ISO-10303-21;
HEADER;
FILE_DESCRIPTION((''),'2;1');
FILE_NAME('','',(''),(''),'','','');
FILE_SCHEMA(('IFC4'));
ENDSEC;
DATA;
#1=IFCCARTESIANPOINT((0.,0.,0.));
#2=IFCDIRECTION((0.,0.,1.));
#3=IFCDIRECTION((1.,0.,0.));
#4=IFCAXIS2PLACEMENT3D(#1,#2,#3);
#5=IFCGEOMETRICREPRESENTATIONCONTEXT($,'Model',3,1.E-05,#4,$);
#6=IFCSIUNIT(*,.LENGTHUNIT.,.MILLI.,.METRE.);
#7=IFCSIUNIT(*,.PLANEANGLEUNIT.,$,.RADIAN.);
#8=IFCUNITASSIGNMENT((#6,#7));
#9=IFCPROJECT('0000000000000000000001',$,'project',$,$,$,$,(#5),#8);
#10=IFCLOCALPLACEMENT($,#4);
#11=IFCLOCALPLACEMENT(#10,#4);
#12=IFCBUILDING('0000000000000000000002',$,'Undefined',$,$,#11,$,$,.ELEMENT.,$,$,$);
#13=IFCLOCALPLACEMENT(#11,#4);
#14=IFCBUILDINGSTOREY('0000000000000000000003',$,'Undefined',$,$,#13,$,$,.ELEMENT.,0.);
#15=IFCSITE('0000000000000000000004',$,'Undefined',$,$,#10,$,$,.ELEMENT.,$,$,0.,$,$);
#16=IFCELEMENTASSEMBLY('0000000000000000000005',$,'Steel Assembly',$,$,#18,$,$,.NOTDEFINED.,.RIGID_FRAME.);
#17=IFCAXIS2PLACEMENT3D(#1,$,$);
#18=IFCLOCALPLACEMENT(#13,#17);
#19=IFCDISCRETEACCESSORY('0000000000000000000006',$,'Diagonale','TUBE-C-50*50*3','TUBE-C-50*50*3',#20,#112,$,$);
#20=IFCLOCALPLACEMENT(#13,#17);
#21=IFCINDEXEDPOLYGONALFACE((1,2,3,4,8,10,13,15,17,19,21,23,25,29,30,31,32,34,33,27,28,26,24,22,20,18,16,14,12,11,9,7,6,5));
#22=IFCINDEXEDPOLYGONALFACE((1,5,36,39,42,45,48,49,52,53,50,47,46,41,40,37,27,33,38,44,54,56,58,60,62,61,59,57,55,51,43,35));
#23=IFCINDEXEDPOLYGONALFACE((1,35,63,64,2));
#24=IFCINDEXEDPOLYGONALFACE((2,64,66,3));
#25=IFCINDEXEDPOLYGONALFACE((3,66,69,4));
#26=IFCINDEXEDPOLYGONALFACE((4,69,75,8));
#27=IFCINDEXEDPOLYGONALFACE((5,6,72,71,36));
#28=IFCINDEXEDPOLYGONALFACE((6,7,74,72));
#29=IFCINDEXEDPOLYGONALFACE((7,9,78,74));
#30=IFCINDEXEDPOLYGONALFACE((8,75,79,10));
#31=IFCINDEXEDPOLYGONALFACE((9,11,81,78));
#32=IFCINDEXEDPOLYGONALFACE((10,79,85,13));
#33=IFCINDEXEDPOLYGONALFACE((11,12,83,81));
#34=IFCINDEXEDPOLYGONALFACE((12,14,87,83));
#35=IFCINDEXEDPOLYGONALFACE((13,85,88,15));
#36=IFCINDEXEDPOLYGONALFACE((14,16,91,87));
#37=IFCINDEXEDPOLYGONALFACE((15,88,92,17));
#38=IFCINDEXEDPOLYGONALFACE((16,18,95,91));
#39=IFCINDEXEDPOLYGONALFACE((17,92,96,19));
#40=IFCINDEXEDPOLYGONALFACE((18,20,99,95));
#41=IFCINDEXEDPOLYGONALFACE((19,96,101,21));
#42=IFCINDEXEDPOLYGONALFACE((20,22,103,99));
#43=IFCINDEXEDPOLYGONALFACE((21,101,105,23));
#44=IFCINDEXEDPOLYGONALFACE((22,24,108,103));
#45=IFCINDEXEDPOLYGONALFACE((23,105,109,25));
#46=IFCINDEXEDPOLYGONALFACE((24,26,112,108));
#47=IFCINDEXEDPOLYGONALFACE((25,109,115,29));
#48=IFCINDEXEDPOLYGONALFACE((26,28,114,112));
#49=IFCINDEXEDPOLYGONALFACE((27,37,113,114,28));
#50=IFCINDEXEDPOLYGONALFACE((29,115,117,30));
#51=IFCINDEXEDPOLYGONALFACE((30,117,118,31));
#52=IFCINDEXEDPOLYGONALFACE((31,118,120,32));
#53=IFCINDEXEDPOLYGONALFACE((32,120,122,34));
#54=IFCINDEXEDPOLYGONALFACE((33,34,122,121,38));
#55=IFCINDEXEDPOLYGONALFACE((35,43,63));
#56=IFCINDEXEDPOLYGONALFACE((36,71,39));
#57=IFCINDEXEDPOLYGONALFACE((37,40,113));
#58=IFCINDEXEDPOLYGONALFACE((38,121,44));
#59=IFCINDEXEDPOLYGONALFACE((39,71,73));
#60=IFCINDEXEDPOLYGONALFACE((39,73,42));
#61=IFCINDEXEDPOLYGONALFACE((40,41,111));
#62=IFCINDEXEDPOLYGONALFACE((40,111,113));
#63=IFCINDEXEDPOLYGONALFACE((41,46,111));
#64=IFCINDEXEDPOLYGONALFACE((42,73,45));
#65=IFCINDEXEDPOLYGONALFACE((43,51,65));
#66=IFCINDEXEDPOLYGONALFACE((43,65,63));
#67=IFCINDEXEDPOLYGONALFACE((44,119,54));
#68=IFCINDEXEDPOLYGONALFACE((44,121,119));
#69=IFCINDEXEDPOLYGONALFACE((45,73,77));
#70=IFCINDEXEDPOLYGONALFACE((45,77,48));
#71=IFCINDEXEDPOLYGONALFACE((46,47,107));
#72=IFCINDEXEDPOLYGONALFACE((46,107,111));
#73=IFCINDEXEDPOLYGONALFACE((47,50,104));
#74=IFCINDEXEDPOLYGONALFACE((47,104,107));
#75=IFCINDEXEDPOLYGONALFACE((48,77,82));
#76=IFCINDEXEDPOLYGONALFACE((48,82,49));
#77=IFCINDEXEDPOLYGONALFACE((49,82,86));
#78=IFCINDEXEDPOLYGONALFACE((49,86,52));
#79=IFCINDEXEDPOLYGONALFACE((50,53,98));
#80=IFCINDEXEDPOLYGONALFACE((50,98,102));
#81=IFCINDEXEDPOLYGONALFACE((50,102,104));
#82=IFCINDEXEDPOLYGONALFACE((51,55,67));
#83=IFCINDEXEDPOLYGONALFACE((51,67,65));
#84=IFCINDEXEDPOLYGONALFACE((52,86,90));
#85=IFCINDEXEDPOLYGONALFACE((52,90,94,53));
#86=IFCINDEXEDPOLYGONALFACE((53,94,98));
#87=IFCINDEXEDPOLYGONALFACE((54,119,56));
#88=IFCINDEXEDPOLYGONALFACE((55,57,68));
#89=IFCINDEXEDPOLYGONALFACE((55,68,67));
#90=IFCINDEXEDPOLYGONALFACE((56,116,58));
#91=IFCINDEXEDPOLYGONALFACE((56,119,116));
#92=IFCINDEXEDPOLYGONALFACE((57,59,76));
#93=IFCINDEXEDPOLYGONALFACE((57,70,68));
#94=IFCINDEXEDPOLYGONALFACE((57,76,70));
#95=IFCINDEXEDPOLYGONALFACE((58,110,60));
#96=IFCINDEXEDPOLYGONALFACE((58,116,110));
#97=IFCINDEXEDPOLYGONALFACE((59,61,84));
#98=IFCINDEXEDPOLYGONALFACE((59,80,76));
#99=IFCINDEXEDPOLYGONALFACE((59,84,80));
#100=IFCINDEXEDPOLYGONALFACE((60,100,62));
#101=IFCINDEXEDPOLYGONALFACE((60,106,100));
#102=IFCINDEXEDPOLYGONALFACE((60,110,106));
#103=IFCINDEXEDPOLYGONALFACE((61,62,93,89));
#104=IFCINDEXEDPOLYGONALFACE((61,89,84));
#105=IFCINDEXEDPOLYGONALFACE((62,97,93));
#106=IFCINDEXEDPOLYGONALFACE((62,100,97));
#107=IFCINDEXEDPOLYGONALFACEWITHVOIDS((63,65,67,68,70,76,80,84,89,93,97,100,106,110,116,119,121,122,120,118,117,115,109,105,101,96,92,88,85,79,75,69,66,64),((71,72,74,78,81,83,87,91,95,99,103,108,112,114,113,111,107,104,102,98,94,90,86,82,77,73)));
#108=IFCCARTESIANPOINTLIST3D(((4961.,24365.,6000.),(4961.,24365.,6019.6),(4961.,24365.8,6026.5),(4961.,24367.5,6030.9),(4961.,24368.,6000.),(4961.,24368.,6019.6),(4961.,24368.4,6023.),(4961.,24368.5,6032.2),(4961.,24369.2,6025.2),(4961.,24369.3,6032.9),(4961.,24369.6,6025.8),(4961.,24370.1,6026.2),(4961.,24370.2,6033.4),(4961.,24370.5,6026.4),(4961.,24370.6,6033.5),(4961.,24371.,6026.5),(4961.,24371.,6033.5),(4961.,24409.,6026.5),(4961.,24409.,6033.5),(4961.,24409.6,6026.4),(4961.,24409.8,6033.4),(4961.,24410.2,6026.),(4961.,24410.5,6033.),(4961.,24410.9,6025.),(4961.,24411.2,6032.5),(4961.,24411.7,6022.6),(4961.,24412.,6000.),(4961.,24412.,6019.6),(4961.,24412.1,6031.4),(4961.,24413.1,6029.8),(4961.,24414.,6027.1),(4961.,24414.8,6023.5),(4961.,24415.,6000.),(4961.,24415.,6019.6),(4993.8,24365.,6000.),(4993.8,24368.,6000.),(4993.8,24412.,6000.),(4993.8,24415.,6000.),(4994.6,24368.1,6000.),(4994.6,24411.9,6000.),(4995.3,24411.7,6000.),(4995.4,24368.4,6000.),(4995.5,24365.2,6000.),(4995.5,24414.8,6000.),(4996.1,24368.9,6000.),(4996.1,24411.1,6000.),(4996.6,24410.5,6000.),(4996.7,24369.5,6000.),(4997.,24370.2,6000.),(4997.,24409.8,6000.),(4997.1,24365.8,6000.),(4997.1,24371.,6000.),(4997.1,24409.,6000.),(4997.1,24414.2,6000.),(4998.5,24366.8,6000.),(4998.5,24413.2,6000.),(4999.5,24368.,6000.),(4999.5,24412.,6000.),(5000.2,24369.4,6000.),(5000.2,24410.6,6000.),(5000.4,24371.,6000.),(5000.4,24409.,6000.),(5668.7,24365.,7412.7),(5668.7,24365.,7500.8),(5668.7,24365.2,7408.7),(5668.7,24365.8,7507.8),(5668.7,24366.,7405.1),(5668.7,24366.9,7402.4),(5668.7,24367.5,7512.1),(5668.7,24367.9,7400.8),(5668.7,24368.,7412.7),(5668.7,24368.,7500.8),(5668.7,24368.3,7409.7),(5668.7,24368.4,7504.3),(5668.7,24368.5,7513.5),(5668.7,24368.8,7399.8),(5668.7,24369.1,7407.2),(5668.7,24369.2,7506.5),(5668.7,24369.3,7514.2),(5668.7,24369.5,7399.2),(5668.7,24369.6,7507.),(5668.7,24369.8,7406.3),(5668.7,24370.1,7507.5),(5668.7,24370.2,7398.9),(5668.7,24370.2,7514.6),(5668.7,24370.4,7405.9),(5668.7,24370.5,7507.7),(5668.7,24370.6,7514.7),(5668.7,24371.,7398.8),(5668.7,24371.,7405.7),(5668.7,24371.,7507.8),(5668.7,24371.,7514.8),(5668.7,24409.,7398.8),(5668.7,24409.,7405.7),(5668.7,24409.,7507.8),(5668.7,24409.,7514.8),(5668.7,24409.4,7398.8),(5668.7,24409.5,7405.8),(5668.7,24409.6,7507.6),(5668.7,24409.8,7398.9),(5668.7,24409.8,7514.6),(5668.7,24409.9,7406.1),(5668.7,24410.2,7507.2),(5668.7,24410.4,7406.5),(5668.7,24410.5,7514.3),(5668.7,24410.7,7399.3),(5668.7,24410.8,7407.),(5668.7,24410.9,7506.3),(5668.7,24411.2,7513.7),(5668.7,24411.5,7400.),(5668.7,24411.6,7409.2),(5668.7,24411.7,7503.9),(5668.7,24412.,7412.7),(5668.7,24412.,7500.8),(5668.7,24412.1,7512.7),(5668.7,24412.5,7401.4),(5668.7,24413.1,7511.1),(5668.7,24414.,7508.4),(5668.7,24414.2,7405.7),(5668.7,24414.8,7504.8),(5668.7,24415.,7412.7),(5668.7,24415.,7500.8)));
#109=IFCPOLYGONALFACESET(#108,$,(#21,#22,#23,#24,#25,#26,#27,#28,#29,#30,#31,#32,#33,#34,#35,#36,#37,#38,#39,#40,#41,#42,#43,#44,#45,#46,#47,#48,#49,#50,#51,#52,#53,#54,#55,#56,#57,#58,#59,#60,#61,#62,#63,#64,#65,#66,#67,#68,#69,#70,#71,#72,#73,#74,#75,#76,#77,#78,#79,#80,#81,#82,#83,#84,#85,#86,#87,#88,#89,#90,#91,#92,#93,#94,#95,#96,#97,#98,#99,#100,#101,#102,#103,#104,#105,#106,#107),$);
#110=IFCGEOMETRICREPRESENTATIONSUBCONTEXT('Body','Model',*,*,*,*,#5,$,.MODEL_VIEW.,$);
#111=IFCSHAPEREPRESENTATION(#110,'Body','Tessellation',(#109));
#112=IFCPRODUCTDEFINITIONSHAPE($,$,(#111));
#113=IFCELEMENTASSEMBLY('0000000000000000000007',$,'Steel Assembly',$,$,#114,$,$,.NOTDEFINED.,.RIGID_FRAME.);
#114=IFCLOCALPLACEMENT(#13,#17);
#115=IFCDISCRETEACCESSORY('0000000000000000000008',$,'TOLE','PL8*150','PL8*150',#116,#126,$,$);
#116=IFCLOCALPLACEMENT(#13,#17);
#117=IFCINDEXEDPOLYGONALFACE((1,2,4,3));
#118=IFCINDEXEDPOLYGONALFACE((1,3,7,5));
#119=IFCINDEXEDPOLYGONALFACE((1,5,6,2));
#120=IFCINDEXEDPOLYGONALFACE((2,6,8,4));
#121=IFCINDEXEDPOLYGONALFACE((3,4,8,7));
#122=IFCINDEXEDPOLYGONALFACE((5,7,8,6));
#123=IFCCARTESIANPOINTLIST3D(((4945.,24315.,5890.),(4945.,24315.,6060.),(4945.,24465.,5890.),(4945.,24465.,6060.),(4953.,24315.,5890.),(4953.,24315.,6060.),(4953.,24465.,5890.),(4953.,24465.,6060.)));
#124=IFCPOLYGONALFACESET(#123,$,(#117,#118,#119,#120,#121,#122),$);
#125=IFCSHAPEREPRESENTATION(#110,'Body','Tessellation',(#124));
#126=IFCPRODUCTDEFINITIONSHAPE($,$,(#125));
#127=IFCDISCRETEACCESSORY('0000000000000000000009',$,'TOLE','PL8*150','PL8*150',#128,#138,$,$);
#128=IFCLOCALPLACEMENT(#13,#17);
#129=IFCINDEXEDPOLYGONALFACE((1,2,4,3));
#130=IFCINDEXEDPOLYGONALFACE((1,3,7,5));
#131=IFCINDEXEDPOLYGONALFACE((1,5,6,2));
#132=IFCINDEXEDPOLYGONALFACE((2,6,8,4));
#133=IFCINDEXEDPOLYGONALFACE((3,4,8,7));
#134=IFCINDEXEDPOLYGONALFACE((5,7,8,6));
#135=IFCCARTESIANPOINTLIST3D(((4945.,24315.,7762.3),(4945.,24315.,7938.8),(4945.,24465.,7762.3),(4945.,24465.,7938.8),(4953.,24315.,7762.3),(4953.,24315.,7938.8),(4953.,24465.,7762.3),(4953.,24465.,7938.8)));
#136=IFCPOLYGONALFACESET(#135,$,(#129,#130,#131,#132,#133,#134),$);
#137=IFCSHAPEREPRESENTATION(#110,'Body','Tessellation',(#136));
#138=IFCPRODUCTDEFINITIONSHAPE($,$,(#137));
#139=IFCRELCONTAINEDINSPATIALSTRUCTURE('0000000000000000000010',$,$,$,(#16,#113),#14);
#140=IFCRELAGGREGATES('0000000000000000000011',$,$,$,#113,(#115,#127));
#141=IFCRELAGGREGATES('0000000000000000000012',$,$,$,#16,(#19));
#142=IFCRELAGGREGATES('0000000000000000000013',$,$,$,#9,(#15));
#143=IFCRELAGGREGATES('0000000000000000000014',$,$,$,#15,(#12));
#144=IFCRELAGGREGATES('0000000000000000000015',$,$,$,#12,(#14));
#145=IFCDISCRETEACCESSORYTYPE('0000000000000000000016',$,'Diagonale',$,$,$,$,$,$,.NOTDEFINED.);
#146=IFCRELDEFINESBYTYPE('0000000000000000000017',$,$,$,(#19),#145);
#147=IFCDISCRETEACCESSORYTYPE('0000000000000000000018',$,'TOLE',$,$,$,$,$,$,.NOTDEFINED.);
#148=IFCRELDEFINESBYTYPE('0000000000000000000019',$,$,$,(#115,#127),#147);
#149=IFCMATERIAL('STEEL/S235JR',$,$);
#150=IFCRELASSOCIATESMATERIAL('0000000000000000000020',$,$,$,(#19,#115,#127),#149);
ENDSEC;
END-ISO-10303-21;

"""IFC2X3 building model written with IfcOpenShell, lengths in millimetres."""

from ifc_helpers import new_model, si_unit, frame, origin_with_axes, origin_2d_with_axis, place, context, subcontext, project, spatial, polyline, hollow_rectangle, outline, extrude, clip, halfspace, material, type_object, element, aggregate, save


model = new_model("IFC2X3")

# Units and contexts
model_context = context("Model", 3, precision=1e-05, world=origin_with_axes())
body_context = subcontext(model_context, "Body", "Model", "MODEL_VIEW")
ifc_project = project(units=[si_unit("LENGTHUNIT", "METRE", prefix="MILLI"), si_unit("PLANEANGLEUNIT", "RADIAN")], contexts=[model_context])

# Site, building, storey
site_placement = place(None, origin_with_axes())
site = spatial("IfcSite", under=ifc_project, at=site_placement, Name="Undefined", CompositionType="ELEMENT", RefElevation=0.0)
building_placement = place(site_placement, origin_with_axes())
building = spatial("IfcBuilding", under=site, at=building_placement, Name="Undefined", CompositionType="ELEMENT")
storey_placement = place(building_placement, origin_with_axes())
storey = spatial("IfcBuildingStorey", under=building, at=storey_placement, Name="Undefined", CompositionType="ELEMENT", Elevation=0.0)

# Shared definitions
ifc_material_1 = material(Name="STEEL/S235JR")

# Element assembly
assembly_1_placement = place(storey_placement, origin_with_axes())
assembly_1 = element("IfcElementAssembly", 1, at=assembly_1_placement, inside=storey, Name="Steel Assembly", AssemblyPlace="NOTDEFINED", PredefinedType="RIGID_FRAME")

# Discrete accessory
discrete_accessory_type_1 = type_object("IfcDiscreteAccessoryType", Name="Diagonale")
discrete_accessory_1_placement = place(assembly_1_placement, frame((4967.6, 24390.0, 5989.2), z_axis=(-0.902299, 0.0, 0.431112), x_axis=(0.431112, 0.0, 0.902299)))
discrete_accessory_1 = element("IfcDiscreteAccessory", 2, at=discrete_accessory_1_placement, type_object=discrete_accessory_type_1, material=ifc_material_1, Name="Diagonale", Description="TUBE-C-50*50*3", ObjectType="TUBE-C-50*50*3", context=body_context, shape_type="Clipping", body=[
    clip(clip(clip(extrude(hollow_rectangle(XDim=50.0, YDim=50.0, WallThickness=3.0, InnerFilletRadius=3.0, OuterFilletRadius=6.0, at=origin_2d_with_axis()), frame((1684.4, 0.0, 0.0), z_axis=(-1.0, 0.0, 0.0), x_axis=(0.0, -1.0, 0.0)), (0.0, 0.0, 1.0), 1730.4), halfspace(frame((-67.5, 25.0, -25.0), z_axis=(-0.431116, 0.0, 0.902297), x_axis=(0.902297, 0.0, 0.431116)), False)), halfspace(frame((1662.5, 0.0, 17.2), z_axis=(-0.431112, 0.0, 0.902299), x_axis=(0.0, -1.0, 0.0)), True)), halfspace(frame((34.2, 0.0, -46.6), z_axis=(0.902299, 0.0, 0.431112), x_axis=(0.0, -1.0, 0.0)), True)),
])

# Element assembly, discrete accessories
assembly_2_placement = place(storey_placement, origin_with_axes())
assembly_2 = element("IfcElementAssembly", 3, at=assembly_2_placement, inside=storey, Name="Steel Assembly", AssemblyPlace="NOTDEFINED", PredefinedType="RIGID_FRAME")
discrete_accessory_type_2 = type_object("IfcDiscreteAccessoryType", Name="TOLE")
discrete_accessory_2_placement = place(assembly_2_placement, frame((4949.0, 24390.0, 5890.0), z_axis=(1.0, 0.0, 0.000005), x_axis=(-0.000005, 0.0, 1.0)))
discrete_accessory_2 = element("IfcDiscreteAccessory", 4, at=discrete_accessory_2_placement, type_object=discrete_accessory_type_2, material=ifc_material_1, Name="TOLE", Description="PL8*150", ObjectType="PL8*150", context=body_context, shape_type="SweptSolid", body=[
    extrude(outline(polyline([(170.0, 75.0), (170.0, -75.0), (0.0, -75.0), (0.0, 75.0), (170.0, 75.0)])), frame((0.0, 0.0, -4.0), z_axis=(0.0, 0.0, 1.0), x_axis=(1.0, 0.0, 0.0)), (0.0, 0.0, 1.0), 8.0),
])
discrete_accessory_3_placement = place(assembly_2_placement, frame((4949.0, 24390.0, 7762.3), z_axis=(1.0, 0.0, 0.000005), x_axis=(-0.000005, 0.0, 1.0)))
discrete_accessory_3 = element("IfcDiscreteAccessory", 5, at=discrete_accessory_3_placement, type_object=discrete_accessory_type_2, material=ifc_material_1, Name="TOLE", Description="PL8*150", ObjectType="PL8*150", context=body_context, shape_type="SweptSolid", body=[
    extrude(outline(polyline([(176.4, 75.0), (176.4, -75.0), (0.0, -75.0), (0.0, 75.0), (176.4, 75.0)])), frame((0.0, 0.0, -4.0), z_axis=(0.0, 0.0, 1.0), x_axis=(1.0, 0.0, 0.0)), (0.0, 0.0, 1.0), 8.0),
])
aggregate(assembly_2, [discrete_accessory_2, discrete_accessory_3])

aggregate(assembly_1, [discrete_accessory_1])

save(model, "model.ifc")
